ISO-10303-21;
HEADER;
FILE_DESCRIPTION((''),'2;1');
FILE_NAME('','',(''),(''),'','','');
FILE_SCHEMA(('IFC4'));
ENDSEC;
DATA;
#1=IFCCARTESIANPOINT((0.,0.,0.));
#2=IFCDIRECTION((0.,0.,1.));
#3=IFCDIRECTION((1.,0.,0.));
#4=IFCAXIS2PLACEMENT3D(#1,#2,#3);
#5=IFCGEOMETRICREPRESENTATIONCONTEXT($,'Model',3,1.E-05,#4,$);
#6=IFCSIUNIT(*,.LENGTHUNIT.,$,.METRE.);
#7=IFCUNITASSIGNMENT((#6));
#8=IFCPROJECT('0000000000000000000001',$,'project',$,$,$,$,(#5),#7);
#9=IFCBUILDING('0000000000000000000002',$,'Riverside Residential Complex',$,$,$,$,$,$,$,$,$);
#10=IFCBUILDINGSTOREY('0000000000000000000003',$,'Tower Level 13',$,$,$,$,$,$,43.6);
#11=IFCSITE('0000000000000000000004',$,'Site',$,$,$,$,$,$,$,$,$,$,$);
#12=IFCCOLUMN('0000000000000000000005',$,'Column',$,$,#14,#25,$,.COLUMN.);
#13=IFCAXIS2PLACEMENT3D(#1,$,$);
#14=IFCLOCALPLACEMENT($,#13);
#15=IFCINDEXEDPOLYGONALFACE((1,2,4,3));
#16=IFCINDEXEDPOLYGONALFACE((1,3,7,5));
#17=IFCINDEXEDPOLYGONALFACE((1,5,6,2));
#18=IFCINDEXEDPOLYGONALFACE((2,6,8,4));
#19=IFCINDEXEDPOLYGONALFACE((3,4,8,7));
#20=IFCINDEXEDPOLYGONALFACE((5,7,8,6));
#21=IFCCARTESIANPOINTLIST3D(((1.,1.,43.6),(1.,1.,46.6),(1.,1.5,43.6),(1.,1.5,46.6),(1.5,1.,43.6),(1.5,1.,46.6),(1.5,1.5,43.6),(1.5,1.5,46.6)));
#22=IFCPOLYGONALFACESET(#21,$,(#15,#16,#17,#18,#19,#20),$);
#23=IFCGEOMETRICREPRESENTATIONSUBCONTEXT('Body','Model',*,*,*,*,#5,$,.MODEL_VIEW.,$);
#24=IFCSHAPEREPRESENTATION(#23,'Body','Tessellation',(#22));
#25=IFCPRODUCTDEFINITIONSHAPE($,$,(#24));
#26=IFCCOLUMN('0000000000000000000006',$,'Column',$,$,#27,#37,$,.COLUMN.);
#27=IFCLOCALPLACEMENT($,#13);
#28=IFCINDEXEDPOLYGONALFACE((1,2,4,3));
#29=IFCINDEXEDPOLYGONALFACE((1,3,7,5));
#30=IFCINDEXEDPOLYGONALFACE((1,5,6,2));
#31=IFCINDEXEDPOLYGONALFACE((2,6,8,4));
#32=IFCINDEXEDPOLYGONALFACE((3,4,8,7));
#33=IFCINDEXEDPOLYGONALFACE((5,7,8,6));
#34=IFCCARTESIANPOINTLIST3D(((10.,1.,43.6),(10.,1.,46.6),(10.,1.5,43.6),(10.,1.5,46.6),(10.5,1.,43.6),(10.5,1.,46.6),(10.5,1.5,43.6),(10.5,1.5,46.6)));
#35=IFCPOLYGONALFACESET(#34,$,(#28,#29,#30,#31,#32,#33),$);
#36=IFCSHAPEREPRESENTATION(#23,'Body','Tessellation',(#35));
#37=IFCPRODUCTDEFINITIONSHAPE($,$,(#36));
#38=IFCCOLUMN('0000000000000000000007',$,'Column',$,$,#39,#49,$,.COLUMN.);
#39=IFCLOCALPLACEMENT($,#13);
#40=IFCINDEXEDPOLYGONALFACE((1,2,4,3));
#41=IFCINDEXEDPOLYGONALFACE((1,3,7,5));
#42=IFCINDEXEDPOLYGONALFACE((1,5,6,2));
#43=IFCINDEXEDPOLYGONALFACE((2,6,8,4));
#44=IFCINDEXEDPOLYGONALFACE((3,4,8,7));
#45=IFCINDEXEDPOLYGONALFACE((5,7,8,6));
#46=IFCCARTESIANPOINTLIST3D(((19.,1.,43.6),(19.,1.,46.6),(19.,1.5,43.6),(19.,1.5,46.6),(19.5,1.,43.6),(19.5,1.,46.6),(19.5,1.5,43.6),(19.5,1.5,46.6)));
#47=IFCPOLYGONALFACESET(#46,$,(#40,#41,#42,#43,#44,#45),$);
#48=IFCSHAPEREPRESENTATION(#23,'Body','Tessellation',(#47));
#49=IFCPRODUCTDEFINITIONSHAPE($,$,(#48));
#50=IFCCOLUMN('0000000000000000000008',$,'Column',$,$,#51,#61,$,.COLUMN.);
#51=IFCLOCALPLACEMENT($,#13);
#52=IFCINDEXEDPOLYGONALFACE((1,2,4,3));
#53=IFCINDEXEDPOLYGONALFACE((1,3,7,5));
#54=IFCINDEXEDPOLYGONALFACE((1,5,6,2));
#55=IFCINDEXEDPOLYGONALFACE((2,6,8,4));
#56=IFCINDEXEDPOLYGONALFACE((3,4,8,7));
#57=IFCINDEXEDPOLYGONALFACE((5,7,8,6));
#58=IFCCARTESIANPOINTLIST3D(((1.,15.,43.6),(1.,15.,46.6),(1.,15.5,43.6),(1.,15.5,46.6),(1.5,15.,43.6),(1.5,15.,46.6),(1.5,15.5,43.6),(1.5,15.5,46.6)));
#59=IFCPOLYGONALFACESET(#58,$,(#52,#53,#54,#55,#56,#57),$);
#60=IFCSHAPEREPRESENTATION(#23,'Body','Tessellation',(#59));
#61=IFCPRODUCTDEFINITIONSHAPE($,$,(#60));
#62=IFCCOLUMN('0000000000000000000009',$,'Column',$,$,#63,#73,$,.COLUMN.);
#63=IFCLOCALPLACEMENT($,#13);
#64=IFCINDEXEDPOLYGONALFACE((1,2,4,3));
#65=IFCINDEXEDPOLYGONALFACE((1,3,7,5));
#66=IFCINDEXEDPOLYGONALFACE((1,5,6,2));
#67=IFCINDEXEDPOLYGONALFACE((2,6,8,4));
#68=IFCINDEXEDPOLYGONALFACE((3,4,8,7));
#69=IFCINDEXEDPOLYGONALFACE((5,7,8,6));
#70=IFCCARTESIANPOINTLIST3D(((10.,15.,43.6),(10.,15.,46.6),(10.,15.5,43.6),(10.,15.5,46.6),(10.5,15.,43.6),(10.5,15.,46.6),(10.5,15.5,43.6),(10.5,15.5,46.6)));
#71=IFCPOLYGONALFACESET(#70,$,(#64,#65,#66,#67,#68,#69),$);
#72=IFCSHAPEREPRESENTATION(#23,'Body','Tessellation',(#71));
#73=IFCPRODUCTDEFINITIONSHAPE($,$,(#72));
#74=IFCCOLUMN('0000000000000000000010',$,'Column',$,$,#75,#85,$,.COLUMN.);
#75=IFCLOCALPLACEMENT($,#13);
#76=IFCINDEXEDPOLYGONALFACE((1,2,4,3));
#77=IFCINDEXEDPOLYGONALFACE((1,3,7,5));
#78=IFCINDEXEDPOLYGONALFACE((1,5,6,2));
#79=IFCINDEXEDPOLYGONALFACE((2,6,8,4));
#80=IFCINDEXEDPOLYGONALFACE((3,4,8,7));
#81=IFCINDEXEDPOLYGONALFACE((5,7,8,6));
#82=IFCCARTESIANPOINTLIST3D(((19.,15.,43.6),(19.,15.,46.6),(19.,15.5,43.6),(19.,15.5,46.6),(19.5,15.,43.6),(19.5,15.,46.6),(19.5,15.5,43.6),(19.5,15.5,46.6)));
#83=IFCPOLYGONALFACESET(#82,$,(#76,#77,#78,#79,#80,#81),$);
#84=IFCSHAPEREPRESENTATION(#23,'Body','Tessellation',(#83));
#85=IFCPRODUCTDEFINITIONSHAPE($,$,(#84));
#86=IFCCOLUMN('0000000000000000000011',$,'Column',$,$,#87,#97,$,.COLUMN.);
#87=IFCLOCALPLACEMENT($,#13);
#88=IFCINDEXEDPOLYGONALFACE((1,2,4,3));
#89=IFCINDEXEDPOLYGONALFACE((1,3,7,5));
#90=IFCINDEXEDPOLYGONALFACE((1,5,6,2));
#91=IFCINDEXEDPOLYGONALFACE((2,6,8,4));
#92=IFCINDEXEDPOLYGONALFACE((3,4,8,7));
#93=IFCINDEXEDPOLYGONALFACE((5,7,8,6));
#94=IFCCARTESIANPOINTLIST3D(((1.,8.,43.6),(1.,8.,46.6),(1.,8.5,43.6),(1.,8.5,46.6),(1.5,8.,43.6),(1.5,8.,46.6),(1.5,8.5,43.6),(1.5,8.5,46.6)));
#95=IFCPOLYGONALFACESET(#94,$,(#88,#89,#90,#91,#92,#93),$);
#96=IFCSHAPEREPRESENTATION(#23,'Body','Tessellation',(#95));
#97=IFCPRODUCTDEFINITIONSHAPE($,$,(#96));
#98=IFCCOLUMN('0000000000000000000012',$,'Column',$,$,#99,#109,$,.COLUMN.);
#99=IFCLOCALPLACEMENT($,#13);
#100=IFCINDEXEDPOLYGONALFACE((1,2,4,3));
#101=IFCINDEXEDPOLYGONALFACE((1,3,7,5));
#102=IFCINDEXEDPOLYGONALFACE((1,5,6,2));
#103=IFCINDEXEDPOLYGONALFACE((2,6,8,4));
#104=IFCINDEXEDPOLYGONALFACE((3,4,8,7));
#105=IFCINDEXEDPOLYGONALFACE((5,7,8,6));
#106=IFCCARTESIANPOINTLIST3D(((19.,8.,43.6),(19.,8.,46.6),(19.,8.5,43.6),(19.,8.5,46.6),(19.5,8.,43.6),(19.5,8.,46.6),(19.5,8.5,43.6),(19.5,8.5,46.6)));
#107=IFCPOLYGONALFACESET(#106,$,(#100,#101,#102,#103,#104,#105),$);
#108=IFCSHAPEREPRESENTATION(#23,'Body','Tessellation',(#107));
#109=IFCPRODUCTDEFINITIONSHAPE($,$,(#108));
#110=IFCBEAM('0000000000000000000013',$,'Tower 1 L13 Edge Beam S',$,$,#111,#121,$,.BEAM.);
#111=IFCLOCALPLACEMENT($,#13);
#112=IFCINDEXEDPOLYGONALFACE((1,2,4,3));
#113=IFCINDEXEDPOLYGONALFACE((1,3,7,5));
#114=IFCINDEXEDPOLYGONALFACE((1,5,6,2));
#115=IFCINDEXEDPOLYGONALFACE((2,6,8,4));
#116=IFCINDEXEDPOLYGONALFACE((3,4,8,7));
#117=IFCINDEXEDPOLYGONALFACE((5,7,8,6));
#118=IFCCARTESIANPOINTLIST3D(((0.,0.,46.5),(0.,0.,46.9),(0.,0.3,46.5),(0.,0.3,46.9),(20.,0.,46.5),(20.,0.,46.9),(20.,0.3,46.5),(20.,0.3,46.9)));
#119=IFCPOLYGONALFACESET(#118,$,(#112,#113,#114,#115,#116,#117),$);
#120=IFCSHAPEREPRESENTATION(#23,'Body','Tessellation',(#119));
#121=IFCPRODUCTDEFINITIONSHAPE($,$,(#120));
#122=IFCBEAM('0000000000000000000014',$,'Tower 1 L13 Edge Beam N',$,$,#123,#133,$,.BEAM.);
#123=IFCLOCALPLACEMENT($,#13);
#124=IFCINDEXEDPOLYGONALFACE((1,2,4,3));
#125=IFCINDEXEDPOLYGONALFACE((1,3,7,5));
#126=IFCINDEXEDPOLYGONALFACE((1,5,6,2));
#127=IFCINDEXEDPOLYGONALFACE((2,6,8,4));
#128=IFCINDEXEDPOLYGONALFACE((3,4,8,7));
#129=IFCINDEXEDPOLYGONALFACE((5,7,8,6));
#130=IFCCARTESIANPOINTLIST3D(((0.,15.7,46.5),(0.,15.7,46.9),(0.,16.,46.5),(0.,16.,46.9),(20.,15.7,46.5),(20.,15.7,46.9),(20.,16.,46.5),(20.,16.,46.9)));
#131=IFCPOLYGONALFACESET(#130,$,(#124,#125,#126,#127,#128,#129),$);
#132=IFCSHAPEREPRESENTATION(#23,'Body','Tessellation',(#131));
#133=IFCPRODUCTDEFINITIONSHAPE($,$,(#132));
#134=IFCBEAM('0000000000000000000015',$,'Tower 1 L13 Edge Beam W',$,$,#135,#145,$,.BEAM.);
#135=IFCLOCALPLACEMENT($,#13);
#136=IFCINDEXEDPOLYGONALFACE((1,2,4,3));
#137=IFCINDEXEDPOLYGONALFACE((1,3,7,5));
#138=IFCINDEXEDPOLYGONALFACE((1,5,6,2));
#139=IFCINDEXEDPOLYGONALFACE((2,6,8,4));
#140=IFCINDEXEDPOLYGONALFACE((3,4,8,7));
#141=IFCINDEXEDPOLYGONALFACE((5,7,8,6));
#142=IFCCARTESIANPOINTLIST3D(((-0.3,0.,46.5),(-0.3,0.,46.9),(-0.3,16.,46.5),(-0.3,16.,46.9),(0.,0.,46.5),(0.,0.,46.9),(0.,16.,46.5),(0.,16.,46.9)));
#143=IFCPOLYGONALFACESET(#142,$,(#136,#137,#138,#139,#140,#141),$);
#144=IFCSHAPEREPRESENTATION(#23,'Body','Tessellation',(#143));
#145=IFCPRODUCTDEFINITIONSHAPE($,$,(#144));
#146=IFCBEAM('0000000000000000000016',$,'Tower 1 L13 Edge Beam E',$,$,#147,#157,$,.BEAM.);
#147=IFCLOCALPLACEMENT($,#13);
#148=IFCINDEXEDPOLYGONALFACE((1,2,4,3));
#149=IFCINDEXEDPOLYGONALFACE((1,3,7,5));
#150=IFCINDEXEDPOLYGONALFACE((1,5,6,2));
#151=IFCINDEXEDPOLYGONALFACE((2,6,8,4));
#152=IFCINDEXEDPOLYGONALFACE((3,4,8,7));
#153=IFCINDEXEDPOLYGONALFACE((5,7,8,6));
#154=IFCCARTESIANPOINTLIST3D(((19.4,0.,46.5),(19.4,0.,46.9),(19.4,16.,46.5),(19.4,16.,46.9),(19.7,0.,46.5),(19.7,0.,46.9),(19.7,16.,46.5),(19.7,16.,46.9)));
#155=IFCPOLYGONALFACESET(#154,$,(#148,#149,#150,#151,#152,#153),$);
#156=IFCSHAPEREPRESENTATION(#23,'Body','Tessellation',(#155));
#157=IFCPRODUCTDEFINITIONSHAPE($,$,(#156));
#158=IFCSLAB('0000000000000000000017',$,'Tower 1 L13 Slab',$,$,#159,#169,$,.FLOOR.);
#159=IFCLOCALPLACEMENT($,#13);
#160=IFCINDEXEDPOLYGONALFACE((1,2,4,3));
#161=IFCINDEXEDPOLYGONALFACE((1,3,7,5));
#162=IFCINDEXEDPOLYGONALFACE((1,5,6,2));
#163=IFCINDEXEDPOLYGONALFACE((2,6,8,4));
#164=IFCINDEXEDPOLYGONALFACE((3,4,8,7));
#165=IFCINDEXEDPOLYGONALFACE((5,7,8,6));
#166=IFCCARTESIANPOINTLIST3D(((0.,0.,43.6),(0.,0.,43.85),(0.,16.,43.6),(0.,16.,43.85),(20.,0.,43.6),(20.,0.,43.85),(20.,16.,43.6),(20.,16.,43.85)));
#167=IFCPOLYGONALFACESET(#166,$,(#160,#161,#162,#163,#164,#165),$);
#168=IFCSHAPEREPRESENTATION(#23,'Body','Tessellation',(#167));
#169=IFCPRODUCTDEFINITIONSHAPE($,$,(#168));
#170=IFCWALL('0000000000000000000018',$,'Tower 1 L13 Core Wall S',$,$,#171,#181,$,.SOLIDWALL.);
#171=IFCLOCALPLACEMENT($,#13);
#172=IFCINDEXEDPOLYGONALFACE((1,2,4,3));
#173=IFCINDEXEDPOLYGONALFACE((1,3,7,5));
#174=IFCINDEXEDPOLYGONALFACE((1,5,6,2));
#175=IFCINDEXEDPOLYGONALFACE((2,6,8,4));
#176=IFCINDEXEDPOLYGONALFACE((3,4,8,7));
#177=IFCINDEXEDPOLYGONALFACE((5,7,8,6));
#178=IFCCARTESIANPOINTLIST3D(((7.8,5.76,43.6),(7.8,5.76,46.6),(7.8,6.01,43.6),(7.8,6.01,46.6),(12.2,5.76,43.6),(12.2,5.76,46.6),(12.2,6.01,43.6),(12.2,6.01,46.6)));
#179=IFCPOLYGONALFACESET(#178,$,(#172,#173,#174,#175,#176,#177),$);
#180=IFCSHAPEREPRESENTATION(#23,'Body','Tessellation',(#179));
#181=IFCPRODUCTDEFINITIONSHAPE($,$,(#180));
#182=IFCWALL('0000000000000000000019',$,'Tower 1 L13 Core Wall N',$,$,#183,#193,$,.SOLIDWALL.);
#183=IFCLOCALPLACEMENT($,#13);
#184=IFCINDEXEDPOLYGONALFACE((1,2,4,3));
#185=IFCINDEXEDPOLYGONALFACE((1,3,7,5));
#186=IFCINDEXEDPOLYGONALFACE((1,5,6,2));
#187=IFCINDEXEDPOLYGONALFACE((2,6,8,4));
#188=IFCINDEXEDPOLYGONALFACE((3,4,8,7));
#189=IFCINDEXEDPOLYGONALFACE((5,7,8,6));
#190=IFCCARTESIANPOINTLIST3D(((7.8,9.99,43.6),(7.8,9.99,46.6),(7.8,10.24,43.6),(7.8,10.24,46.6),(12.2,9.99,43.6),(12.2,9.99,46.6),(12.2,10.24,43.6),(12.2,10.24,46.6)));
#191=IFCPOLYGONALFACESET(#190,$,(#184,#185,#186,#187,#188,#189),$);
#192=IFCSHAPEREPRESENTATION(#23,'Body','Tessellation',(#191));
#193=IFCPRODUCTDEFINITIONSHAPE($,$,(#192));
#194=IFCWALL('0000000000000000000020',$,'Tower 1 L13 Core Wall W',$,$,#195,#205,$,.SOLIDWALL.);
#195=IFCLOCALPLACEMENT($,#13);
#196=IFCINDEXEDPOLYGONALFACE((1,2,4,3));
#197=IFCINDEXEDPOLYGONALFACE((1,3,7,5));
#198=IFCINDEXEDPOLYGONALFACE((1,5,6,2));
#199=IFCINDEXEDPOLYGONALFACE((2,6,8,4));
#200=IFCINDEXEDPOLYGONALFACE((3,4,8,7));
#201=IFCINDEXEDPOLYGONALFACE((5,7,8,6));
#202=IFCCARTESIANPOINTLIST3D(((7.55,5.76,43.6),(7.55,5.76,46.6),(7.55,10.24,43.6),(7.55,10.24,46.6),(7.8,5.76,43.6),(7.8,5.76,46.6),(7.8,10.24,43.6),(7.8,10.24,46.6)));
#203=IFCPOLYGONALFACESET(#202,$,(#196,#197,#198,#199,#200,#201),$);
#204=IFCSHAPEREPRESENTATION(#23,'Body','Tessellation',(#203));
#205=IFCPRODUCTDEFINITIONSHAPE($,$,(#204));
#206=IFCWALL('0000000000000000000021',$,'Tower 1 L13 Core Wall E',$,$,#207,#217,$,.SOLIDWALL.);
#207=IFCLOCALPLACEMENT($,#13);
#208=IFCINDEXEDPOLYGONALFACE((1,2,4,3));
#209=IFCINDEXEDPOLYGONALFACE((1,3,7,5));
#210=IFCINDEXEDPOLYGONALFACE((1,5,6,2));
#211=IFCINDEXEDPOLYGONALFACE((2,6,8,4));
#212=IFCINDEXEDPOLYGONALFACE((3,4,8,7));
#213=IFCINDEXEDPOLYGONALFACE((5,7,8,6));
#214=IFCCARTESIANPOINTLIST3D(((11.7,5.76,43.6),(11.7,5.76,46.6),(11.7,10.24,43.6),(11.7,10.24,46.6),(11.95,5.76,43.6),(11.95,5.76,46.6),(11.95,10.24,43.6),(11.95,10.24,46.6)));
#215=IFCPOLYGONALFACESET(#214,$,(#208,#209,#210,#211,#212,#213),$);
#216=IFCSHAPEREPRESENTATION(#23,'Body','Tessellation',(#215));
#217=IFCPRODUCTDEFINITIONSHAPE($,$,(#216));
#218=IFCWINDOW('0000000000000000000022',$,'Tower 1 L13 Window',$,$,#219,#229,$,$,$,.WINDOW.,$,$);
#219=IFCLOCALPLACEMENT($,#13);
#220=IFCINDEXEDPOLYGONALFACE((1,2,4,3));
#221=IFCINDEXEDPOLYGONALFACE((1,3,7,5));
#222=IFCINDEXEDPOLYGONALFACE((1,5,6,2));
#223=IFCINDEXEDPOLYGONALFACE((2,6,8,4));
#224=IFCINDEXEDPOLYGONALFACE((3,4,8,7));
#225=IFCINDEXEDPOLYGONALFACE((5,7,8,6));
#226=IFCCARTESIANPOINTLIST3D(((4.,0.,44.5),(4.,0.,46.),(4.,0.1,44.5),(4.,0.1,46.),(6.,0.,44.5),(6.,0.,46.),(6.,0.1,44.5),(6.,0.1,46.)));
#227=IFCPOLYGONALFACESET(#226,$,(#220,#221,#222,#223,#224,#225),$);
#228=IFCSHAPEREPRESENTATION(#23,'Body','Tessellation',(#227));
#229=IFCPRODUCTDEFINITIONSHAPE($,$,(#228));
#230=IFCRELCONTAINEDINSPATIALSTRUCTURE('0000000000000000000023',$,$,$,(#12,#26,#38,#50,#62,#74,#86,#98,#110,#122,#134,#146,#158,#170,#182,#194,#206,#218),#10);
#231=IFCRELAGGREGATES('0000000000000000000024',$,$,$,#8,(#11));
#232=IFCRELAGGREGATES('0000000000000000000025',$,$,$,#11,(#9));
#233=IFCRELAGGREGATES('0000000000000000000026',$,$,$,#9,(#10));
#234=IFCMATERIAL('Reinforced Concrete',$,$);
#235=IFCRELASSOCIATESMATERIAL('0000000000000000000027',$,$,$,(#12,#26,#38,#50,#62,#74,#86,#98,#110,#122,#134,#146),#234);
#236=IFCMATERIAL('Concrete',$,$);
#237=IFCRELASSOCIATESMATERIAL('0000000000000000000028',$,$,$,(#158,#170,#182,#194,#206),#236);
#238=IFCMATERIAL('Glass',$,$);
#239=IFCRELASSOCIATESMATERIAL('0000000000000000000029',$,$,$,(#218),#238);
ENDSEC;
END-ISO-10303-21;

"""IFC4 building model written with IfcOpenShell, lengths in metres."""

from ifc_helpers import new_model, si_unit, frame, origin_with_axes, place, context, subcontext, project, spatial, line, indexed_curve, outline, extrude, material, element, save


model = new_model("IFC4")

# Units and contexts
model_context = context("Model", 3, precision=1e-05, world=origin_with_axes())
body_context = subcontext(model_context, "Body", "Model", "MODEL_VIEW")
ifc_project = project(units=[si_unit("LENGTHUNIT", "METRE")], contexts=[model_context])

# Site, building, storey
site = spatial("IfcSite", under=ifc_project, Name="Site")
building = spatial("IfcBuilding", under=site, Name="Riverside Residential Complex")
storey = spatial("IfcBuildingStorey", under=building, Name="Tower Level 13", Elevation=43.6)

# Columns
ifc_material_1 = material(Name="Reinforced Concrete")
for number, where, z_axis, x_axis, name in (
    (1, (1.0, 1.0, 43.6), (0.0, 0.0, 1.0), (1.0, 0.0, 0.0), "Column"),
    (2, (10.0, 1.0, 43.6), (0.0, 0.0, 1.0), (1.0, 0.0, 0.0), "Column"),
    (3, (19.0, 1.0, 43.6), (0.0, 0.0, 1.0), (1.0, 0.0, 0.0), "Column"),
    (4, (1.0, 15.0, 43.6), (0.0, 0.0, 1.0), (1.0, 0.0, 0.0), "Column"),
    (5, (10.0, 15.0, 43.6), (0.0, 0.0, 1.0), (1.0, 0.0, 0.0), "Column"),
    (6, (19.0, 15.0, 43.6), (0.0, 0.0, 1.0), (1.0, 0.0, 0.0), "Column"),
    (7, (1.0, 8.0, 43.6), (0.0, 0.0, 1.0), (1.0, 0.0, 0.0), "Column"),
    (8, (19.0, 8.0, 43.6), (0.0, 0.0, 1.0), (1.0, 0.0, 0.0), "Column"),
):
    element("IfcColumn", number, at=place(None, frame(where, z_axis=z_axis, x_axis=x_axis)), inside=storey, material=ifc_material_1, Name=name, PredefinedType="COLUMN", context=body_context, shape_type="SweptSolid", body=[
        extrude(outline(indexed_curve([(0.0, 0.0), (0.5, 0.0), (0.5, 0.5), (0.0, 0.5)], segments=[line(1, 2, 3, 4, 1)])), origin_with_axes(), (0.0, 0.0, 1.0), 3.0),
    ])

# Beams
for number, where, z_axis, x_axis, name in (
    (9, (0.0, 0.0, 46.5), (0.0, 0.0, 1.0), (1.0, 0.0, 0.0), "Tower 1 L13 Edge Beam S"),
    (10, (0.0, 15.7, 46.5), (0.0, 0.0, 1.0), (1.0, 0.0, 0.0), "Tower 1 L13 Edge Beam N"),
):
    element("IfcBeam", number, at=place(None, frame(where, z_axis=z_axis, x_axis=x_axis)), inside=storey, material=ifc_material_1, Name=name, PredefinedType="BEAM", context=body_context, shape_type="SweptSolid", body=[
        extrude(outline(indexed_curve([(0.0, 0.0), (20.0, 0.0), (20.0, 0.3), (0.0, 0.3)], segments=[line(1, 2, 3, 4, 1)])), origin_with_axes(), (0.0, 0.0, 1.0), 0.4),
    ])
for number, where, z_axis, x_axis, name in (
    (11, (0.0, 0.0, 46.5), (0.0, 0.0, 1.0), (0.0, 1.0, 0.0), "Tower 1 L13 Edge Beam W"),
    (12, (19.7, 0.0, 46.5), (0.0, 0.0, 1.0), (0.0, 1.0, 0.0), "Tower 1 L13 Edge Beam E"),
):
    element("IfcBeam", number, at=place(None, frame(where, z_axis=z_axis, x_axis=x_axis)), inside=storey, material=ifc_material_1, Name=name, PredefinedType="BEAM", context=body_context, shape_type="SweptSolid", body=[
        extrude(outline(indexed_curve([(0.0, 0.0), (16.0, 0.0), (16.0, 0.3), (0.0, 0.3)], segments=[line(1, 2, 3, 4, 1)])), origin_with_axes(), (0.0, 0.0, 1.0), 0.4),
    ])

# Slab
ifc_material_2 = material(Name="Concrete")
slab_placement = place(None, frame((0.0, 0.0, 43.6), z_axis=(0.0, 0.0, 1.0), x_axis=(1.0, 0.0, 0.0)))
element("IfcSlab", 13, at=slab_placement, inside=storey, material=ifc_material_2, Name="Tower 1 L13 Slab", PredefinedType="FLOOR", context=body_context, shape_type="SweptSolid", body=[
    extrude(outline(indexed_curve([(0.0, 0.0), (20.0, 0.0), (20.0, 16.0), (0.0, 16.0)], segments=[line(1, 2, 3, 4, 1)])), origin_with_axes(), (0.0, 0.0, 1.0), 0.25),
])

# Walls
for number, where, z_axis, x_axis, name in (
    (14, (7.8, 5.76, 43.6), (0.0, 0.0, 1.0), (1.0, 0.0, 0.0), "Tower 1 L13 Core Wall S"),
    (15, (7.8, 9.99, 43.6), (0.0, 0.0, 1.0), (1.0, 0.0, 0.0), "Tower 1 L13 Core Wall N"),
):
    element("IfcWall", number, at=place(None, frame(where, z_axis=z_axis, x_axis=x_axis)), inside=storey, material=ifc_material_2, Name=name, PredefinedType="SOLIDWALL", context=body_context, shape_type="SweptSolid", body=[
        extrude(outline(indexed_curve([(0.0, 0.0), (4.4, 0.0), (4.4, 0.25), (0.0, 0.25)], segments=[line(1, 2, 3, 4, 1)])), origin_with_axes(), (0.0, 0.0, 1.0), 3.0),
    ])
for number, where, z_axis, x_axis, name in (
    (16, (7.8, 5.76, 43.6), (0.0, 0.0, 1.0), (0.0, 1.0, 0.0), "Tower 1 L13 Core Wall W"),
    (17, (11.95, 5.76, 43.6), (0.0, 0.0, 1.0), (0.0, 1.0, 0.0), "Tower 1 L13 Core Wall E"),
):
    element("IfcWall", number, at=place(None, frame(where, z_axis=z_axis, x_axis=x_axis)), inside=storey, material=ifc_material_2, Name=name, PredefinedType="SOLIDWALL", context=body_context, shape_type="SweptSolid", body=[
        extrude(outline(indexed_curve([(0.0, 0.0), (4.48, 0.0), (4.48, 0.25), (0.0, 0.25)], segments=[line(1, 2, 3, 4, 1)])), origin_with_axes(), (0.0, 0.0, 1.0), 3.0),
    ])

# Window
ifc_material_3 = material(Name="Glass")
for number, where, z_axis, x_axis, name in (
    (18, (4.0, 0.0, 44.5), (0.0, 0.0, 1.0), (1.0, 0.0, 0.0), "Tower 1 L13 Window"),
):
    element("IfcWindow", number, at=place(None, frame(where, z_axis=z_axis, x_axis=x_axis)), inside=storey, material=ifc_material_3, Name=name, PredefinedType="WINDOW", context=body_context, shape_type="SweptSolid", body=[
        extrude(outline(indexed_curve([(0.0, 0.0), (2.0, 0.0), (2.0, 0.1), (0.0, 0.1)], segments=[line(1, 2, 3, 4, 1)])), origin_with_axes(), (0.0, 0.0, 1.0), 1.5),
    ])

save(model, "model.ifc")
